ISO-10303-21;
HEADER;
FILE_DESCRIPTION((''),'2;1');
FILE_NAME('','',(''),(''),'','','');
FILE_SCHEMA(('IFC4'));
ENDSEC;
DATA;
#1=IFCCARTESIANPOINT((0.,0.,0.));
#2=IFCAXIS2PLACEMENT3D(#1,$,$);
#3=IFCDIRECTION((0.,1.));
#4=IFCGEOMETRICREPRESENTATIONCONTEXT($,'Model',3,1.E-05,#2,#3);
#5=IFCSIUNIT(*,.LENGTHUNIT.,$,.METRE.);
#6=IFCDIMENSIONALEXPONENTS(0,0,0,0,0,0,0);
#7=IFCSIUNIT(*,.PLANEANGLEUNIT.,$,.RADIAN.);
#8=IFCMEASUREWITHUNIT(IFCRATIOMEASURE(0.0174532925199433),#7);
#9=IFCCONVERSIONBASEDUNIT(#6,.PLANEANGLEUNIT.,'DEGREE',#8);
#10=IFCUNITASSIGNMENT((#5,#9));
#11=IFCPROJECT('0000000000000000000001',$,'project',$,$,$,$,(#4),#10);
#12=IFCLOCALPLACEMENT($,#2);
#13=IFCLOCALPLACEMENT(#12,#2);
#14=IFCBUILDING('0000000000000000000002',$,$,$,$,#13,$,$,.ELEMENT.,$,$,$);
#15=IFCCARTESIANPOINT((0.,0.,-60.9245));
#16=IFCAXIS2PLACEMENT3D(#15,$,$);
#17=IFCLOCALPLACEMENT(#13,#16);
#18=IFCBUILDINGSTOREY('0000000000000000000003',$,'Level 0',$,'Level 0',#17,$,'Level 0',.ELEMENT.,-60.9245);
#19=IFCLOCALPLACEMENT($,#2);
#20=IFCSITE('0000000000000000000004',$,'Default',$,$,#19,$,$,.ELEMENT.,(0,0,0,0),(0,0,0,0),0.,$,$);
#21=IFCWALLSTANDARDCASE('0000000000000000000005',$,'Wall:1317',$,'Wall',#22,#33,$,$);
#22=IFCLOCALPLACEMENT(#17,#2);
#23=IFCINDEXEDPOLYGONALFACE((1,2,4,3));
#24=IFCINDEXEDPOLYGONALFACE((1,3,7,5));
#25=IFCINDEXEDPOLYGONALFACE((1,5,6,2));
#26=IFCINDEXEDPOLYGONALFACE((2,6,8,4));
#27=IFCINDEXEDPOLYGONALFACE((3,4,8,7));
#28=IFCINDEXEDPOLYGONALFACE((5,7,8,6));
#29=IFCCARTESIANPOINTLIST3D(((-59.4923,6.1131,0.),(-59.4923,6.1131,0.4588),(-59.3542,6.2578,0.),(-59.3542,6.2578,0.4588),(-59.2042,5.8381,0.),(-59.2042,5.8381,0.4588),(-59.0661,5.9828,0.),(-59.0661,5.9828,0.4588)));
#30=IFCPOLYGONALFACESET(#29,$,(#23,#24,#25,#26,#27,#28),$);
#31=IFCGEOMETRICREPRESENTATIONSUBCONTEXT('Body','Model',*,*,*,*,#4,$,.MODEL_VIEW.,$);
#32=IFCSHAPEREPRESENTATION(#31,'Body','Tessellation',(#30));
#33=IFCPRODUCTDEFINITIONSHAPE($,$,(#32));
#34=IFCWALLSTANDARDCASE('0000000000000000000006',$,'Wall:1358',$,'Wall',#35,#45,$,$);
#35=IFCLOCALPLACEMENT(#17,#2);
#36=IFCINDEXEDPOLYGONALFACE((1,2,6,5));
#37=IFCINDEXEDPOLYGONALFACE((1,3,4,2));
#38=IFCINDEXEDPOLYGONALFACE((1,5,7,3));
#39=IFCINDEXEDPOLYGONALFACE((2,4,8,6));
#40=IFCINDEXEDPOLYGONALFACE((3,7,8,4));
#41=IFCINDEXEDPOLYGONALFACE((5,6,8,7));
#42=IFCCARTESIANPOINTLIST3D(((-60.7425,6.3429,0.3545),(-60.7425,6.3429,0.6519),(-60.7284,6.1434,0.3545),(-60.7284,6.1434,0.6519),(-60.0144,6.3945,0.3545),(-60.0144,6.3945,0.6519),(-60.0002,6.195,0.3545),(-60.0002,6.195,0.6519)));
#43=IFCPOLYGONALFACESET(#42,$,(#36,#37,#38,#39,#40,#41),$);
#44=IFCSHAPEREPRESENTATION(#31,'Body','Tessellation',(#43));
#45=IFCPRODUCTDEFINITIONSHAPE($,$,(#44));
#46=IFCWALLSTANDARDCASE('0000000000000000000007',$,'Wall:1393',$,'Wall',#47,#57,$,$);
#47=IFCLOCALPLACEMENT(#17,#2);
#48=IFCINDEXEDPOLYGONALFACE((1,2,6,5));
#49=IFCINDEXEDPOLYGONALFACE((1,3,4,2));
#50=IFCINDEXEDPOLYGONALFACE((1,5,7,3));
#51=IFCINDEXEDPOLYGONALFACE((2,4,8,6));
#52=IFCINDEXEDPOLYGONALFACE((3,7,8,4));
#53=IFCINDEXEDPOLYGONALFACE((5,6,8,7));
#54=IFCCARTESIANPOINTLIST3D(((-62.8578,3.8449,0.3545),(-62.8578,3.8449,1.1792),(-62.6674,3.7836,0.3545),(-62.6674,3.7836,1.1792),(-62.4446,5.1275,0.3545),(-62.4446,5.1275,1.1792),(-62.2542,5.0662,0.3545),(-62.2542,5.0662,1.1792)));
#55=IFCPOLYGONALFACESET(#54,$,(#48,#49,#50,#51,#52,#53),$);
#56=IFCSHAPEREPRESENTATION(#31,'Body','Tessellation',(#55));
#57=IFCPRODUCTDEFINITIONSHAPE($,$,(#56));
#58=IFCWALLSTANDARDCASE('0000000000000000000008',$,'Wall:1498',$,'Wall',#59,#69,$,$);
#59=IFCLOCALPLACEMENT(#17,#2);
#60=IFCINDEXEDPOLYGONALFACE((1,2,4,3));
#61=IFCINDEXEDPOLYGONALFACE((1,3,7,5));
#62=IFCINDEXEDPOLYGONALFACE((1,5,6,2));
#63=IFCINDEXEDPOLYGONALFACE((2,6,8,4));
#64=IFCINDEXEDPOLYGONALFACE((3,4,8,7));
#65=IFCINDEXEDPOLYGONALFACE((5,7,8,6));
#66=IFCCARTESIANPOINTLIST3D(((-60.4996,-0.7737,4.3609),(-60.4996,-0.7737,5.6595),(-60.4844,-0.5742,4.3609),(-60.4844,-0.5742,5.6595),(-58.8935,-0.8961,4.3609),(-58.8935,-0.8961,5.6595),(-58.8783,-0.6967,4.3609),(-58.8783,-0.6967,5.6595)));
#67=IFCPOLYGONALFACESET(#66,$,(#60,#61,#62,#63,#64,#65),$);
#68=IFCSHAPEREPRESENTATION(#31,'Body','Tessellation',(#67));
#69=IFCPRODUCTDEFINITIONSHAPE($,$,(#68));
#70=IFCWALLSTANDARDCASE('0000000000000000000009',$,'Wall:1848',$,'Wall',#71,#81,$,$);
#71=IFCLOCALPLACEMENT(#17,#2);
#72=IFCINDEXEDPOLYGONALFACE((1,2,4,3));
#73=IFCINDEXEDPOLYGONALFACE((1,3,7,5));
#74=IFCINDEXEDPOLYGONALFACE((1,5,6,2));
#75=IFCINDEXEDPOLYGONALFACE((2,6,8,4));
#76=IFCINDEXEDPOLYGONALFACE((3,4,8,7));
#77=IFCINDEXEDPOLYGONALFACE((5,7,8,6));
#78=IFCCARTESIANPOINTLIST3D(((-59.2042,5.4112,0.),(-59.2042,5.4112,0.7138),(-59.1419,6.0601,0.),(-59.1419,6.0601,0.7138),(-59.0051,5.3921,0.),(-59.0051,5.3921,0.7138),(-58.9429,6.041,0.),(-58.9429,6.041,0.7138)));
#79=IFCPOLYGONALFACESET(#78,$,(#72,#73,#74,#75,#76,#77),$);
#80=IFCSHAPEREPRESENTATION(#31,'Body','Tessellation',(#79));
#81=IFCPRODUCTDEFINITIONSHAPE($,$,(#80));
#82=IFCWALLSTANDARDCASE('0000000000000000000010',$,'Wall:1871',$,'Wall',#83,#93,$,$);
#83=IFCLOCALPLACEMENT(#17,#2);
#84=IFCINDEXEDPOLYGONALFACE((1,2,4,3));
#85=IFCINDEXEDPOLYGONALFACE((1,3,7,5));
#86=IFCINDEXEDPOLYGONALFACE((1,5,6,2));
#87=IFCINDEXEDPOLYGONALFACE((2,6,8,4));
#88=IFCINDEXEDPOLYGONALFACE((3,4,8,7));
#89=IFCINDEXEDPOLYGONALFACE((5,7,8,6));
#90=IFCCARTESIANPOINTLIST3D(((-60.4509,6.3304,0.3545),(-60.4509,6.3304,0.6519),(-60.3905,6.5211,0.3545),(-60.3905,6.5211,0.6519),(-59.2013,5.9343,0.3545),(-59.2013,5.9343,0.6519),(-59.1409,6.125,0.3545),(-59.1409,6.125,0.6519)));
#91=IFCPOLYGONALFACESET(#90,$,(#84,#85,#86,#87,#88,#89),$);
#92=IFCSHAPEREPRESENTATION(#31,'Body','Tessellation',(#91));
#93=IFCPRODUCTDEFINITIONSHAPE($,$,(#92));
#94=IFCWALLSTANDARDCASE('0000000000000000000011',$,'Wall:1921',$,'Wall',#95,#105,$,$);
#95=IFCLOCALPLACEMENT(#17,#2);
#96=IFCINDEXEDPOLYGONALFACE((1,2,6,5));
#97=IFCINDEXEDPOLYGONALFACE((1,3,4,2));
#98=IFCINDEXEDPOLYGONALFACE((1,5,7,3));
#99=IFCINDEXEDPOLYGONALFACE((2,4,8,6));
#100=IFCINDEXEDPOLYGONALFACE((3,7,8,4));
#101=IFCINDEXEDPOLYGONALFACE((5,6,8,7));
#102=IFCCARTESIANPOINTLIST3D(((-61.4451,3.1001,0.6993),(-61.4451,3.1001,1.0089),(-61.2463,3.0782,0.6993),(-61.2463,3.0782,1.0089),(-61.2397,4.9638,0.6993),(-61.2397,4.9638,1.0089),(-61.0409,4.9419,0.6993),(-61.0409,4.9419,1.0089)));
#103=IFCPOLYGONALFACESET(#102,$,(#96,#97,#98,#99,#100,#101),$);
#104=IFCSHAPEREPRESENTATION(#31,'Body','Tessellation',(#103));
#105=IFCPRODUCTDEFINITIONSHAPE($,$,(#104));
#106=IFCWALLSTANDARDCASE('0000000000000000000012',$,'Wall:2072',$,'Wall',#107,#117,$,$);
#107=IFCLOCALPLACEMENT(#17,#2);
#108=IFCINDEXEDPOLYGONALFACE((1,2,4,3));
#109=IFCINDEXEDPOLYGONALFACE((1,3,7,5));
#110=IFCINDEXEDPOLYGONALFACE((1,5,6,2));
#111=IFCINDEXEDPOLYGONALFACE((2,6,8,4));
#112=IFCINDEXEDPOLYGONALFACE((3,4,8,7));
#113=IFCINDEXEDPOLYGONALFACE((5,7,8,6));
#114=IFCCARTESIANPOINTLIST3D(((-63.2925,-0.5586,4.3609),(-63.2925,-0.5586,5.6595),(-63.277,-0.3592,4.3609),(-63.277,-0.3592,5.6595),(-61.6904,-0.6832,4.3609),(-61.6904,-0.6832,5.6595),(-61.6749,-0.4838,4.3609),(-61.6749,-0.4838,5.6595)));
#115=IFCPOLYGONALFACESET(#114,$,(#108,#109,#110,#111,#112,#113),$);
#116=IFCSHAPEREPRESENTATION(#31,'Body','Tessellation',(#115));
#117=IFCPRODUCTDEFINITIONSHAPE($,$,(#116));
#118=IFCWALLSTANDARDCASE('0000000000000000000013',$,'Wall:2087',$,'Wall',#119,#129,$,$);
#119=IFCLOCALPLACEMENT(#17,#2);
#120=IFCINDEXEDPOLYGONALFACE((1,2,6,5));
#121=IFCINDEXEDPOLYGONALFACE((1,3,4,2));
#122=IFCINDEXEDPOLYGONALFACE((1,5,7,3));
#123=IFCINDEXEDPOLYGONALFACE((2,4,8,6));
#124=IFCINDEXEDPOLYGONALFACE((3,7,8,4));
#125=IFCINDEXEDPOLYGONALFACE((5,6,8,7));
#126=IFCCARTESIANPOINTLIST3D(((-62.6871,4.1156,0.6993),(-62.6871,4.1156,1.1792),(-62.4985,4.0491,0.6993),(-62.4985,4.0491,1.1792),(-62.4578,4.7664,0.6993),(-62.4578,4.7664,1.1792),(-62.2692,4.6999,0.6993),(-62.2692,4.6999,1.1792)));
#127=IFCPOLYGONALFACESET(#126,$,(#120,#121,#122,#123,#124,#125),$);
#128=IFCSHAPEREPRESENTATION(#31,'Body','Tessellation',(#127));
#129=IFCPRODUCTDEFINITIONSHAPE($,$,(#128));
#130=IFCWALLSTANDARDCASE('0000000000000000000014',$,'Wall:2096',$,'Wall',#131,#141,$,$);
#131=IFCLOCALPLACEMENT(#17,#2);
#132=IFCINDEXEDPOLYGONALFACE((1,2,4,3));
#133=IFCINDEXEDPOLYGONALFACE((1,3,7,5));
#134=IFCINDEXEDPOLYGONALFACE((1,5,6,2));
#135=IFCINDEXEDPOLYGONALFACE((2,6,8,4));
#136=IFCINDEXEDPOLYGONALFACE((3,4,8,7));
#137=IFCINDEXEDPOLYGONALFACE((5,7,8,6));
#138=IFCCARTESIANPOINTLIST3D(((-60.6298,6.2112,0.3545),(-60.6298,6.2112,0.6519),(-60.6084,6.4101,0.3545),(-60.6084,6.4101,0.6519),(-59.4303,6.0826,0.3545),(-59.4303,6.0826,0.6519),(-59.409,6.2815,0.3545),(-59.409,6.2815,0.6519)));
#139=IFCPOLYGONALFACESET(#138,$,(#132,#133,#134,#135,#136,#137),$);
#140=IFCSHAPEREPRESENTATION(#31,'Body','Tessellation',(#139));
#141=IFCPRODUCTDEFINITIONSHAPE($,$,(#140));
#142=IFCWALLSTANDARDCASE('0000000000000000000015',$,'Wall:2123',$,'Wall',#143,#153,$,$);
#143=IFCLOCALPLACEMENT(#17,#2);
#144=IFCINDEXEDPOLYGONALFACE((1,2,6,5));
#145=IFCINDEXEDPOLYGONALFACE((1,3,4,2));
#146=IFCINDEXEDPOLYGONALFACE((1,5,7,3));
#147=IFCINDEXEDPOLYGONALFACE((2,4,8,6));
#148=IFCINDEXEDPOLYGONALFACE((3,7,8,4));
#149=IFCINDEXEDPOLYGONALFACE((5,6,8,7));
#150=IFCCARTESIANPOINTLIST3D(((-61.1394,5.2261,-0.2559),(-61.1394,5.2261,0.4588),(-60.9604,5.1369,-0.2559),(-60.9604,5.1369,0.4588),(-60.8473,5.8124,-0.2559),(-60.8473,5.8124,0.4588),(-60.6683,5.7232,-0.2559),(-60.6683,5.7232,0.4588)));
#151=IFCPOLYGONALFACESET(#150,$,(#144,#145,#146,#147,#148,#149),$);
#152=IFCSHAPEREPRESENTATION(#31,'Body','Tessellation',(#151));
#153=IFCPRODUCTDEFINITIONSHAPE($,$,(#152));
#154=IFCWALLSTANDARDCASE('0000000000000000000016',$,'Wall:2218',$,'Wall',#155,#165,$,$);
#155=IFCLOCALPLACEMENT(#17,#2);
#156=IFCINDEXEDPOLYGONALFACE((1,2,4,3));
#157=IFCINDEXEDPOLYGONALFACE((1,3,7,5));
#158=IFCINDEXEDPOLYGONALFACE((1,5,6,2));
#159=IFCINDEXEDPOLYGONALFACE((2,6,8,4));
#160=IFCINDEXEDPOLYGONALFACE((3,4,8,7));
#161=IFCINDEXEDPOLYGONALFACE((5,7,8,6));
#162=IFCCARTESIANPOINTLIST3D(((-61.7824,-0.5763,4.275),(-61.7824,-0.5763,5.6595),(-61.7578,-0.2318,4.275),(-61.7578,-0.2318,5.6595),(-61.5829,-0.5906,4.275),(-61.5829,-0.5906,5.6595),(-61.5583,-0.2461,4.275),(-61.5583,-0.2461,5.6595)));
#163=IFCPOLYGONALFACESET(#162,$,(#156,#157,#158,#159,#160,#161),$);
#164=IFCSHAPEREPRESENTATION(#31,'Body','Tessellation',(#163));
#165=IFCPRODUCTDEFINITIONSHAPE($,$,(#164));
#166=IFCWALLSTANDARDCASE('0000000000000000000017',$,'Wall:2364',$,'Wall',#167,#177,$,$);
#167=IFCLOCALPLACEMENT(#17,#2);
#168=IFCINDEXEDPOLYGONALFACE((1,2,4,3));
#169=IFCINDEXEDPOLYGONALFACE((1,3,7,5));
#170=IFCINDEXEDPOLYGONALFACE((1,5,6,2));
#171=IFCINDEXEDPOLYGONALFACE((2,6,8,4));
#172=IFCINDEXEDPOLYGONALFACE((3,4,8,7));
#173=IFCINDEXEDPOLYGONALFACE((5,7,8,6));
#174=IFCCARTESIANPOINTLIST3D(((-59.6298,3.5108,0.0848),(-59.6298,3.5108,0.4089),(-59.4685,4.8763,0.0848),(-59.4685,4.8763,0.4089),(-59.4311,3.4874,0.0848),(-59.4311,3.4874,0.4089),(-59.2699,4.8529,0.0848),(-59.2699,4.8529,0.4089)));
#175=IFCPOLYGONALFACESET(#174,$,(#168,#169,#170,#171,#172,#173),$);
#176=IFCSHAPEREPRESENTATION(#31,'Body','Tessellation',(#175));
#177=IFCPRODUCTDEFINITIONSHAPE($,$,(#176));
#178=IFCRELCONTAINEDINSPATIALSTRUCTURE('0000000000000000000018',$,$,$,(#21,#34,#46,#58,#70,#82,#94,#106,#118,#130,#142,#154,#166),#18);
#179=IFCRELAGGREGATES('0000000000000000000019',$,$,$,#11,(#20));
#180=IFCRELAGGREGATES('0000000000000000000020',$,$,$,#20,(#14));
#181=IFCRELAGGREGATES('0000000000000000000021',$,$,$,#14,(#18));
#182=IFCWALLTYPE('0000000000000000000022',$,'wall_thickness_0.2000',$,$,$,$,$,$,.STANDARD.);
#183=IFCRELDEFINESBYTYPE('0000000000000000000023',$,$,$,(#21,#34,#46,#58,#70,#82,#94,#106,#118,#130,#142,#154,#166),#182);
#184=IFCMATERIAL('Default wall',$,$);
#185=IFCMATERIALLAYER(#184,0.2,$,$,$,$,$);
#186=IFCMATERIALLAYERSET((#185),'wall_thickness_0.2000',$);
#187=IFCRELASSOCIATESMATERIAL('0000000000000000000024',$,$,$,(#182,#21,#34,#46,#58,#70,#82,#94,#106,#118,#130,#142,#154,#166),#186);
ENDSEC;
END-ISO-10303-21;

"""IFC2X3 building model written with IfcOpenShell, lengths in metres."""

from ifc_helpers import new_model, entity, si_unit, converted_unit, direction, frame, origin, place, context, subcontext, project, spatial, polyline, outline, extrude, material, layer, layer_set, layer_usage, type_object, element, save


model = new_model("IFC2X3")

# Units and contexts
model_context = context("Model", 3, precision=1e-05, world=origin(), true_north=direction((0.0, 1.0)))
body_context = subcontext(model_context, "Body", "Model", "MODEL_VIEW")
ifc_project = project(units=[si_unit("LENGTHUNIT", "METRE"), converted_unit("PLANEANGLEUNIT", "DEGREE", entity("IfcRatioMeasure", 0.0174532925199433), si_unit("PLANEANGLEUNIT", "RADIAN"), dimensions=[0, 0, 0, 0, 0, 0, 0])], contexts=[model_context])

# Site, building, storey
site_placement = place(None, origin())
site = spatial("IfcSite", under=ifc_project, at=site_placement, Name="Default", CompositionType="ELEMENT", RefLatitude=(0, 0, 0, 0), RefLongitude=(0, 0, 0, 0), RefElevation=0.0)
placement_1 = place(None, origin())
building_placement = place(placement_1, origin())
building = spatial("IfcBuilding", under=site, at=building_placement, CompositionType="ELEMENT")
storey_placement = place(building_placement, frame((0.0, 0.0, -60.9245)))
storey = spatial("IfcBuildingStorey", under=building, at=storey_placement, Name="Level 0", ObjectType="Level 0", LongName="Level 0", CompositionType="ELEMENT", Elevation=-60.9245)

# Walls
ifc_material = material(Name="Default wall")
ifc_layer = layer(ifc_material, 0.2)
ifc_layer_set = layer_set([ifc_layer], Name="wall_thickness_0.2000")
ifc_layer_usage = layer_usage(ifc_layer_set, "AXIS2", "POSITIVE", -0.1)
wall_type = type_object("IfcWallType", Name="wall_thickness_0.2000", PredefinedType="STANDARD", material=ifc_layer_set)
wall_1_placement = place(storey_placement, frame((-59.4233, 6.1855, 0.0), z_axis=(0.0, 0.0, 1.0), x_axis=(0.723404, -0.690425, 0.0)))
element("IfcWallStandardCase", 1, at=wall_1_placement, inside=storey, type_object=wall_type, material=ifc_layer_usage, Name="Wall:1317", ObjectType="Wall", context=body_context, shape_type="SweptSolid", body=[
    extrude(outline(polyline([(0.3983, -0.1), (0.3983, 0.1), (0.0, 0.1), (0.0, -0.1), (0.3983, -0.1)])), origin(), (0.0, 0.0, 1.0), 0.4588),
])
placement_2 = place(building_placement, frame((0.0, 0.0, -60.57)))
wall_2_placement = place(placement_2, frame((-60.7355, 6.2431, 0.0), z_axis=(0.0, 0.0, 1.0), x_axis=(0.997501, 0.070653, 0.0)))
element("IfcWallStandardCase", 2, at=wall_2_placement, inside=storey, type_object=wall_type, material=ifc_layer_usage, Name="Wall:1358", ObjectType="Wall", context=body_context, shape_type="SweptSolid", body=[
    extrude(outline(polyline([(0.73, -0.1), (0.73, 0.1), (0.0, 0.1), (0.0, -0.1), (0.73, -0.1)])), origin(), (0.0, 0.0, 1.0), 0.2973),
])
placement_3 = place(building_placement, frame((0.0, 0.0, -60.57)))
wall_3_placement = place(placement_3, frame((-62.7626, 3.8143, 0.0), z_axis=(0.0, 0.0, 1.0), x_axis=(0.306667, 0.951817, 0.0)))
element("IfcWallStandardCase", 3, at=wall_3_placement, inside=storey, type_object=wall_type, material=ifc_layer_usage, Name="Wall:1393", ObjectType="Wall", context=body_context, shape_type="SweptSolid", body=[
    extrude(outline(polyline([(1.3475, -0.1), (1.3475, 0.1), (0.0, 0.1), (0.0, -0.1), (1.3475, -0.1)])), origin(), (0.0, 0.0, 1.0), 0.8247),
])
placement_4 = place(building_placement, frame((0.0, 0.0, -56.5636)))
wall_4_placement = place(placement_4, frame((-60.492, -0.6739, 0.0), z_axis=(0.0, 0.0, 1.0), x_axis=(0.997105, -0.076031, 0.0)))
element("IfcWallStandardCase", 4, at=wall_4_placement, inside=storey, type_object=wall_type, material=ifc_layer_usage, Name="Wall:1498", ObjectType="Wall", context=body_context, shape_type="SweptSolid", body=[
    extrude(outline(polyline([(1.6108, -0.1), (1.6108, 0.1), (0.0, 0.1), (0.0, -0.1), (1.6108, -0.1)])), origin(), (0.0, 0.0, 1.0), 1.2985),
])
wall_5_placement = place(storey_placement, frame((-59.1046, 5.4017, 0.0), z_axis=(0.0, 0.0, 1.0), x_axis=(0.095468, 0.995433, 0.0)))
element("IfcWallStandardCase", 5, at=wall_5_placement, inside=storey, type_object=wall_type, material=ifc_layer_usage, Name="Wall:1848", ObjectType="Wall", context=body_context, shape_type="SweptSolid", body=[
    extrude(outline(polyline([(0.6519, -0.1), (0.6519, 0.1), (0.0, 0.1), (0.0, -0.1), (0.6519, -0.1)])), origin(), (0.0, 0.0, 1.0), 0.7138),
])
placement_5 = place(building_placement, frame((0.0, 0.0, -60.57)))
wall_6_placement = place(placement_5, frame((-60.4207, 6.4257, 0.0), z_axis=(0.0, 0.0, 1.0), x_axis=(0.953256, -0.302163, 0.0)))
element("IfcWallStandardCase", 6, at=wall_6_placement, inside=storey, type_object=wall_type, material=ifc_layer_usage, Name="Wall:1871", ObjectType="Wall", context=body_context, shape_type="SweptSolid", body=[
    extrude(outline(polyline([(1.3109, -0.1), (1.3109, 0.1), (0.0, 0.1), (0.0, -0.1), (1.3109, -0.1)])), origin(), (0.0, 0.0, 1.0), 0.2973),
])
placement_6 = place(building_placement, frame((0.0, 0.0, -60.2252)))
wall_7_placement = place(placement_6, frame((-61.3457, 3.0891, 0.0), z_axis=(0.0, 0.0, 1.0), x_axis=(0.109542, 0.993982, 0.0)))
element("IfcWallStandardCase", 7, at=wall_7_placement, inside=storey, type_object=wall_type, material=ifc_layer_usage, Name="Wall:1921", ObjectType="Wall", context=body_context, shape_type="SweptSolid", body=[
    extrude(outline(polyline([(1.875, -0.1), (1.875, 0.1), (0.0, 0.1), (0.0, -0.1), (1.875, -0.1)])), origin(), (0.0, 0.0, 1.0), 0.3097),
])
placement_7 = place(building_placement, frame((0.0, 0.0, -56.5636)))
wall_8_placement = place(placement_7, frame((-61.6826, -0.5835, 0.0), z_axis=(0.0, 0.0, 1.0), x_axis=(-0.996989, 0.077543, 0.0)))
element("IfcWallStandardCase", 8, at=wall_8_placement, inside=storey, type_object=wall_type, material=ifc_layer_usage, Name="Wall:2072", ObjectType="Wall", context=body_context, shape_type="SweptSolid", body=[
    extrude(outline(polyline([(1.607, -0.1), (1.607, 0.1), (0.0, 0.1), (0.0, -0.1), (1.607, -0.1)])), origin(), (0.0, 0.0, 1.0), 1.2985),
])
placement_8 = place(building_placement, frame((0.0, 0.0, -60.2252)))
wall_9_placement = place(placement_8, frame((-62.5928, 4.0824, 0.0), z_axis=(0.0, 0.0, 1.0), x_axis=(0.332381, 0.943145, 0.0)))
element("IfcWallStandardCase", 9, at=wall_9_placement, inside=storey, type_object=wall_type, material=ifc_layer_usage, Name="Wall:2087", ObjectType="Wall", context=body_context, shape_type="SweptSolid", body=[
    extrude(outline(polyline([(0.69, -0.1), (0.69, 0.1), (0.0, 0.1), (0.0, -0.1), (0.69, -0.1)])), origin(), (0.0, 0.0, 1.0), 0.4799),
])
placement_9 = place(building_placement, frame((0.0, 0.0, -60.57)))
wall_10_placement = place(placement_9, frame((-60.6191, 6.3106, 0.0), z_axis=(0.0, 0.0, 1.0), x_axis=(0.994301, -0.106609, 0.0)))
element("IfcWallStandardCase", 10, at=wall_10_placement, inside=storey, type_object=wall_type, material=ifc_layer_usage, Name="Wall:2096", ObjectType="Wall", context=body_context, shape_type="SweptSolid", body=[
    extrude(outline(polyline([(1.2063, -0.1), (1.2063, 0.1), (0.0, 0.1), (0.0, -0.1), (1.2063, -0.1)])), origin(), (0.0, 0.0, 1.0), 0.2973),
])
placement_10 = place(building_placement, frame((0.0, 0.0, -61.1804)))
wall_11_placement = place(placement_10, frame((-61.0499, 5.1815, 0.0), z_axis=(0.0, 0.0, 1.0), x_axis=(0.44586, 0.895103, 0.0)))
element("IfcWallStandardCase", 11, at=wall_11_placement, inside=storey, type_object=wall_type, material=ifc_layer_usage, Name="Wall:2123", ObjectType="Wall", context=body_context, shape_type="SweptSolid", body=[
    extrude(outline(polyline([(0.655, -0.1), (0.655, 0.1), (0.0, 0.1), (0.0, -0.1), (0.655, -0.1)])), origin(), (0.0, 0.0, 1.0), 0.7147),
])
placement_11 = place(building_placement, frame((0.0, 0.0, -56.6495)))
wall_12_placement = place(placement_11, frame((-61.658, -0.239, 0.0), z_axis=(0.0, 0.0, 1.0), x_axis=(-0.071282, -0.997456, 0.0)))
element("IfcWallStandardCase", 12, at=wall_12_placement, inside=storey, type_object=wall_type, material=ifc_layer_usage, Name="Wall:2218", ObjectType="Wall", context=body_context, shape_type="SweptSolid", body=[
    extrude(outline(polyline([(0.3454, -0.1), (0.3454, 0.1), (0.0, 0.1), (0.0, -0.1), (0.3454, -0.1)])), origin(), (0.0, 0.0, 1.0), 1.3845),
])
placement_12 = place(building_placement, frame((0.0, 0.0, -60.8397)))
wall_13_placement = place(placement_12, frame((-59.5305, 3.4991, 0.0), z_axis=(0.0, 0.0, 1.0), x_axis=(0.117251, 0.993102, 0.0)))
element("IfcWallStandardCase", 13, at=wall_13_placement, inside=storey, type_object=wall_type, material=ifc_layer_usage, Name="Wall:2364", ObjectType="Wall", context=body_context, shape_type="SweptSolid", body=[
    extrude(outline(polyline([(1.375, -0.1), (1.375, 0.1), (0.0, 0.1), (0.0, -0.1), (1.375, -0.1)])), origin(), (0.0, 0.0, 1.0), 0.3241),
])

save(model, "model.ifc")
